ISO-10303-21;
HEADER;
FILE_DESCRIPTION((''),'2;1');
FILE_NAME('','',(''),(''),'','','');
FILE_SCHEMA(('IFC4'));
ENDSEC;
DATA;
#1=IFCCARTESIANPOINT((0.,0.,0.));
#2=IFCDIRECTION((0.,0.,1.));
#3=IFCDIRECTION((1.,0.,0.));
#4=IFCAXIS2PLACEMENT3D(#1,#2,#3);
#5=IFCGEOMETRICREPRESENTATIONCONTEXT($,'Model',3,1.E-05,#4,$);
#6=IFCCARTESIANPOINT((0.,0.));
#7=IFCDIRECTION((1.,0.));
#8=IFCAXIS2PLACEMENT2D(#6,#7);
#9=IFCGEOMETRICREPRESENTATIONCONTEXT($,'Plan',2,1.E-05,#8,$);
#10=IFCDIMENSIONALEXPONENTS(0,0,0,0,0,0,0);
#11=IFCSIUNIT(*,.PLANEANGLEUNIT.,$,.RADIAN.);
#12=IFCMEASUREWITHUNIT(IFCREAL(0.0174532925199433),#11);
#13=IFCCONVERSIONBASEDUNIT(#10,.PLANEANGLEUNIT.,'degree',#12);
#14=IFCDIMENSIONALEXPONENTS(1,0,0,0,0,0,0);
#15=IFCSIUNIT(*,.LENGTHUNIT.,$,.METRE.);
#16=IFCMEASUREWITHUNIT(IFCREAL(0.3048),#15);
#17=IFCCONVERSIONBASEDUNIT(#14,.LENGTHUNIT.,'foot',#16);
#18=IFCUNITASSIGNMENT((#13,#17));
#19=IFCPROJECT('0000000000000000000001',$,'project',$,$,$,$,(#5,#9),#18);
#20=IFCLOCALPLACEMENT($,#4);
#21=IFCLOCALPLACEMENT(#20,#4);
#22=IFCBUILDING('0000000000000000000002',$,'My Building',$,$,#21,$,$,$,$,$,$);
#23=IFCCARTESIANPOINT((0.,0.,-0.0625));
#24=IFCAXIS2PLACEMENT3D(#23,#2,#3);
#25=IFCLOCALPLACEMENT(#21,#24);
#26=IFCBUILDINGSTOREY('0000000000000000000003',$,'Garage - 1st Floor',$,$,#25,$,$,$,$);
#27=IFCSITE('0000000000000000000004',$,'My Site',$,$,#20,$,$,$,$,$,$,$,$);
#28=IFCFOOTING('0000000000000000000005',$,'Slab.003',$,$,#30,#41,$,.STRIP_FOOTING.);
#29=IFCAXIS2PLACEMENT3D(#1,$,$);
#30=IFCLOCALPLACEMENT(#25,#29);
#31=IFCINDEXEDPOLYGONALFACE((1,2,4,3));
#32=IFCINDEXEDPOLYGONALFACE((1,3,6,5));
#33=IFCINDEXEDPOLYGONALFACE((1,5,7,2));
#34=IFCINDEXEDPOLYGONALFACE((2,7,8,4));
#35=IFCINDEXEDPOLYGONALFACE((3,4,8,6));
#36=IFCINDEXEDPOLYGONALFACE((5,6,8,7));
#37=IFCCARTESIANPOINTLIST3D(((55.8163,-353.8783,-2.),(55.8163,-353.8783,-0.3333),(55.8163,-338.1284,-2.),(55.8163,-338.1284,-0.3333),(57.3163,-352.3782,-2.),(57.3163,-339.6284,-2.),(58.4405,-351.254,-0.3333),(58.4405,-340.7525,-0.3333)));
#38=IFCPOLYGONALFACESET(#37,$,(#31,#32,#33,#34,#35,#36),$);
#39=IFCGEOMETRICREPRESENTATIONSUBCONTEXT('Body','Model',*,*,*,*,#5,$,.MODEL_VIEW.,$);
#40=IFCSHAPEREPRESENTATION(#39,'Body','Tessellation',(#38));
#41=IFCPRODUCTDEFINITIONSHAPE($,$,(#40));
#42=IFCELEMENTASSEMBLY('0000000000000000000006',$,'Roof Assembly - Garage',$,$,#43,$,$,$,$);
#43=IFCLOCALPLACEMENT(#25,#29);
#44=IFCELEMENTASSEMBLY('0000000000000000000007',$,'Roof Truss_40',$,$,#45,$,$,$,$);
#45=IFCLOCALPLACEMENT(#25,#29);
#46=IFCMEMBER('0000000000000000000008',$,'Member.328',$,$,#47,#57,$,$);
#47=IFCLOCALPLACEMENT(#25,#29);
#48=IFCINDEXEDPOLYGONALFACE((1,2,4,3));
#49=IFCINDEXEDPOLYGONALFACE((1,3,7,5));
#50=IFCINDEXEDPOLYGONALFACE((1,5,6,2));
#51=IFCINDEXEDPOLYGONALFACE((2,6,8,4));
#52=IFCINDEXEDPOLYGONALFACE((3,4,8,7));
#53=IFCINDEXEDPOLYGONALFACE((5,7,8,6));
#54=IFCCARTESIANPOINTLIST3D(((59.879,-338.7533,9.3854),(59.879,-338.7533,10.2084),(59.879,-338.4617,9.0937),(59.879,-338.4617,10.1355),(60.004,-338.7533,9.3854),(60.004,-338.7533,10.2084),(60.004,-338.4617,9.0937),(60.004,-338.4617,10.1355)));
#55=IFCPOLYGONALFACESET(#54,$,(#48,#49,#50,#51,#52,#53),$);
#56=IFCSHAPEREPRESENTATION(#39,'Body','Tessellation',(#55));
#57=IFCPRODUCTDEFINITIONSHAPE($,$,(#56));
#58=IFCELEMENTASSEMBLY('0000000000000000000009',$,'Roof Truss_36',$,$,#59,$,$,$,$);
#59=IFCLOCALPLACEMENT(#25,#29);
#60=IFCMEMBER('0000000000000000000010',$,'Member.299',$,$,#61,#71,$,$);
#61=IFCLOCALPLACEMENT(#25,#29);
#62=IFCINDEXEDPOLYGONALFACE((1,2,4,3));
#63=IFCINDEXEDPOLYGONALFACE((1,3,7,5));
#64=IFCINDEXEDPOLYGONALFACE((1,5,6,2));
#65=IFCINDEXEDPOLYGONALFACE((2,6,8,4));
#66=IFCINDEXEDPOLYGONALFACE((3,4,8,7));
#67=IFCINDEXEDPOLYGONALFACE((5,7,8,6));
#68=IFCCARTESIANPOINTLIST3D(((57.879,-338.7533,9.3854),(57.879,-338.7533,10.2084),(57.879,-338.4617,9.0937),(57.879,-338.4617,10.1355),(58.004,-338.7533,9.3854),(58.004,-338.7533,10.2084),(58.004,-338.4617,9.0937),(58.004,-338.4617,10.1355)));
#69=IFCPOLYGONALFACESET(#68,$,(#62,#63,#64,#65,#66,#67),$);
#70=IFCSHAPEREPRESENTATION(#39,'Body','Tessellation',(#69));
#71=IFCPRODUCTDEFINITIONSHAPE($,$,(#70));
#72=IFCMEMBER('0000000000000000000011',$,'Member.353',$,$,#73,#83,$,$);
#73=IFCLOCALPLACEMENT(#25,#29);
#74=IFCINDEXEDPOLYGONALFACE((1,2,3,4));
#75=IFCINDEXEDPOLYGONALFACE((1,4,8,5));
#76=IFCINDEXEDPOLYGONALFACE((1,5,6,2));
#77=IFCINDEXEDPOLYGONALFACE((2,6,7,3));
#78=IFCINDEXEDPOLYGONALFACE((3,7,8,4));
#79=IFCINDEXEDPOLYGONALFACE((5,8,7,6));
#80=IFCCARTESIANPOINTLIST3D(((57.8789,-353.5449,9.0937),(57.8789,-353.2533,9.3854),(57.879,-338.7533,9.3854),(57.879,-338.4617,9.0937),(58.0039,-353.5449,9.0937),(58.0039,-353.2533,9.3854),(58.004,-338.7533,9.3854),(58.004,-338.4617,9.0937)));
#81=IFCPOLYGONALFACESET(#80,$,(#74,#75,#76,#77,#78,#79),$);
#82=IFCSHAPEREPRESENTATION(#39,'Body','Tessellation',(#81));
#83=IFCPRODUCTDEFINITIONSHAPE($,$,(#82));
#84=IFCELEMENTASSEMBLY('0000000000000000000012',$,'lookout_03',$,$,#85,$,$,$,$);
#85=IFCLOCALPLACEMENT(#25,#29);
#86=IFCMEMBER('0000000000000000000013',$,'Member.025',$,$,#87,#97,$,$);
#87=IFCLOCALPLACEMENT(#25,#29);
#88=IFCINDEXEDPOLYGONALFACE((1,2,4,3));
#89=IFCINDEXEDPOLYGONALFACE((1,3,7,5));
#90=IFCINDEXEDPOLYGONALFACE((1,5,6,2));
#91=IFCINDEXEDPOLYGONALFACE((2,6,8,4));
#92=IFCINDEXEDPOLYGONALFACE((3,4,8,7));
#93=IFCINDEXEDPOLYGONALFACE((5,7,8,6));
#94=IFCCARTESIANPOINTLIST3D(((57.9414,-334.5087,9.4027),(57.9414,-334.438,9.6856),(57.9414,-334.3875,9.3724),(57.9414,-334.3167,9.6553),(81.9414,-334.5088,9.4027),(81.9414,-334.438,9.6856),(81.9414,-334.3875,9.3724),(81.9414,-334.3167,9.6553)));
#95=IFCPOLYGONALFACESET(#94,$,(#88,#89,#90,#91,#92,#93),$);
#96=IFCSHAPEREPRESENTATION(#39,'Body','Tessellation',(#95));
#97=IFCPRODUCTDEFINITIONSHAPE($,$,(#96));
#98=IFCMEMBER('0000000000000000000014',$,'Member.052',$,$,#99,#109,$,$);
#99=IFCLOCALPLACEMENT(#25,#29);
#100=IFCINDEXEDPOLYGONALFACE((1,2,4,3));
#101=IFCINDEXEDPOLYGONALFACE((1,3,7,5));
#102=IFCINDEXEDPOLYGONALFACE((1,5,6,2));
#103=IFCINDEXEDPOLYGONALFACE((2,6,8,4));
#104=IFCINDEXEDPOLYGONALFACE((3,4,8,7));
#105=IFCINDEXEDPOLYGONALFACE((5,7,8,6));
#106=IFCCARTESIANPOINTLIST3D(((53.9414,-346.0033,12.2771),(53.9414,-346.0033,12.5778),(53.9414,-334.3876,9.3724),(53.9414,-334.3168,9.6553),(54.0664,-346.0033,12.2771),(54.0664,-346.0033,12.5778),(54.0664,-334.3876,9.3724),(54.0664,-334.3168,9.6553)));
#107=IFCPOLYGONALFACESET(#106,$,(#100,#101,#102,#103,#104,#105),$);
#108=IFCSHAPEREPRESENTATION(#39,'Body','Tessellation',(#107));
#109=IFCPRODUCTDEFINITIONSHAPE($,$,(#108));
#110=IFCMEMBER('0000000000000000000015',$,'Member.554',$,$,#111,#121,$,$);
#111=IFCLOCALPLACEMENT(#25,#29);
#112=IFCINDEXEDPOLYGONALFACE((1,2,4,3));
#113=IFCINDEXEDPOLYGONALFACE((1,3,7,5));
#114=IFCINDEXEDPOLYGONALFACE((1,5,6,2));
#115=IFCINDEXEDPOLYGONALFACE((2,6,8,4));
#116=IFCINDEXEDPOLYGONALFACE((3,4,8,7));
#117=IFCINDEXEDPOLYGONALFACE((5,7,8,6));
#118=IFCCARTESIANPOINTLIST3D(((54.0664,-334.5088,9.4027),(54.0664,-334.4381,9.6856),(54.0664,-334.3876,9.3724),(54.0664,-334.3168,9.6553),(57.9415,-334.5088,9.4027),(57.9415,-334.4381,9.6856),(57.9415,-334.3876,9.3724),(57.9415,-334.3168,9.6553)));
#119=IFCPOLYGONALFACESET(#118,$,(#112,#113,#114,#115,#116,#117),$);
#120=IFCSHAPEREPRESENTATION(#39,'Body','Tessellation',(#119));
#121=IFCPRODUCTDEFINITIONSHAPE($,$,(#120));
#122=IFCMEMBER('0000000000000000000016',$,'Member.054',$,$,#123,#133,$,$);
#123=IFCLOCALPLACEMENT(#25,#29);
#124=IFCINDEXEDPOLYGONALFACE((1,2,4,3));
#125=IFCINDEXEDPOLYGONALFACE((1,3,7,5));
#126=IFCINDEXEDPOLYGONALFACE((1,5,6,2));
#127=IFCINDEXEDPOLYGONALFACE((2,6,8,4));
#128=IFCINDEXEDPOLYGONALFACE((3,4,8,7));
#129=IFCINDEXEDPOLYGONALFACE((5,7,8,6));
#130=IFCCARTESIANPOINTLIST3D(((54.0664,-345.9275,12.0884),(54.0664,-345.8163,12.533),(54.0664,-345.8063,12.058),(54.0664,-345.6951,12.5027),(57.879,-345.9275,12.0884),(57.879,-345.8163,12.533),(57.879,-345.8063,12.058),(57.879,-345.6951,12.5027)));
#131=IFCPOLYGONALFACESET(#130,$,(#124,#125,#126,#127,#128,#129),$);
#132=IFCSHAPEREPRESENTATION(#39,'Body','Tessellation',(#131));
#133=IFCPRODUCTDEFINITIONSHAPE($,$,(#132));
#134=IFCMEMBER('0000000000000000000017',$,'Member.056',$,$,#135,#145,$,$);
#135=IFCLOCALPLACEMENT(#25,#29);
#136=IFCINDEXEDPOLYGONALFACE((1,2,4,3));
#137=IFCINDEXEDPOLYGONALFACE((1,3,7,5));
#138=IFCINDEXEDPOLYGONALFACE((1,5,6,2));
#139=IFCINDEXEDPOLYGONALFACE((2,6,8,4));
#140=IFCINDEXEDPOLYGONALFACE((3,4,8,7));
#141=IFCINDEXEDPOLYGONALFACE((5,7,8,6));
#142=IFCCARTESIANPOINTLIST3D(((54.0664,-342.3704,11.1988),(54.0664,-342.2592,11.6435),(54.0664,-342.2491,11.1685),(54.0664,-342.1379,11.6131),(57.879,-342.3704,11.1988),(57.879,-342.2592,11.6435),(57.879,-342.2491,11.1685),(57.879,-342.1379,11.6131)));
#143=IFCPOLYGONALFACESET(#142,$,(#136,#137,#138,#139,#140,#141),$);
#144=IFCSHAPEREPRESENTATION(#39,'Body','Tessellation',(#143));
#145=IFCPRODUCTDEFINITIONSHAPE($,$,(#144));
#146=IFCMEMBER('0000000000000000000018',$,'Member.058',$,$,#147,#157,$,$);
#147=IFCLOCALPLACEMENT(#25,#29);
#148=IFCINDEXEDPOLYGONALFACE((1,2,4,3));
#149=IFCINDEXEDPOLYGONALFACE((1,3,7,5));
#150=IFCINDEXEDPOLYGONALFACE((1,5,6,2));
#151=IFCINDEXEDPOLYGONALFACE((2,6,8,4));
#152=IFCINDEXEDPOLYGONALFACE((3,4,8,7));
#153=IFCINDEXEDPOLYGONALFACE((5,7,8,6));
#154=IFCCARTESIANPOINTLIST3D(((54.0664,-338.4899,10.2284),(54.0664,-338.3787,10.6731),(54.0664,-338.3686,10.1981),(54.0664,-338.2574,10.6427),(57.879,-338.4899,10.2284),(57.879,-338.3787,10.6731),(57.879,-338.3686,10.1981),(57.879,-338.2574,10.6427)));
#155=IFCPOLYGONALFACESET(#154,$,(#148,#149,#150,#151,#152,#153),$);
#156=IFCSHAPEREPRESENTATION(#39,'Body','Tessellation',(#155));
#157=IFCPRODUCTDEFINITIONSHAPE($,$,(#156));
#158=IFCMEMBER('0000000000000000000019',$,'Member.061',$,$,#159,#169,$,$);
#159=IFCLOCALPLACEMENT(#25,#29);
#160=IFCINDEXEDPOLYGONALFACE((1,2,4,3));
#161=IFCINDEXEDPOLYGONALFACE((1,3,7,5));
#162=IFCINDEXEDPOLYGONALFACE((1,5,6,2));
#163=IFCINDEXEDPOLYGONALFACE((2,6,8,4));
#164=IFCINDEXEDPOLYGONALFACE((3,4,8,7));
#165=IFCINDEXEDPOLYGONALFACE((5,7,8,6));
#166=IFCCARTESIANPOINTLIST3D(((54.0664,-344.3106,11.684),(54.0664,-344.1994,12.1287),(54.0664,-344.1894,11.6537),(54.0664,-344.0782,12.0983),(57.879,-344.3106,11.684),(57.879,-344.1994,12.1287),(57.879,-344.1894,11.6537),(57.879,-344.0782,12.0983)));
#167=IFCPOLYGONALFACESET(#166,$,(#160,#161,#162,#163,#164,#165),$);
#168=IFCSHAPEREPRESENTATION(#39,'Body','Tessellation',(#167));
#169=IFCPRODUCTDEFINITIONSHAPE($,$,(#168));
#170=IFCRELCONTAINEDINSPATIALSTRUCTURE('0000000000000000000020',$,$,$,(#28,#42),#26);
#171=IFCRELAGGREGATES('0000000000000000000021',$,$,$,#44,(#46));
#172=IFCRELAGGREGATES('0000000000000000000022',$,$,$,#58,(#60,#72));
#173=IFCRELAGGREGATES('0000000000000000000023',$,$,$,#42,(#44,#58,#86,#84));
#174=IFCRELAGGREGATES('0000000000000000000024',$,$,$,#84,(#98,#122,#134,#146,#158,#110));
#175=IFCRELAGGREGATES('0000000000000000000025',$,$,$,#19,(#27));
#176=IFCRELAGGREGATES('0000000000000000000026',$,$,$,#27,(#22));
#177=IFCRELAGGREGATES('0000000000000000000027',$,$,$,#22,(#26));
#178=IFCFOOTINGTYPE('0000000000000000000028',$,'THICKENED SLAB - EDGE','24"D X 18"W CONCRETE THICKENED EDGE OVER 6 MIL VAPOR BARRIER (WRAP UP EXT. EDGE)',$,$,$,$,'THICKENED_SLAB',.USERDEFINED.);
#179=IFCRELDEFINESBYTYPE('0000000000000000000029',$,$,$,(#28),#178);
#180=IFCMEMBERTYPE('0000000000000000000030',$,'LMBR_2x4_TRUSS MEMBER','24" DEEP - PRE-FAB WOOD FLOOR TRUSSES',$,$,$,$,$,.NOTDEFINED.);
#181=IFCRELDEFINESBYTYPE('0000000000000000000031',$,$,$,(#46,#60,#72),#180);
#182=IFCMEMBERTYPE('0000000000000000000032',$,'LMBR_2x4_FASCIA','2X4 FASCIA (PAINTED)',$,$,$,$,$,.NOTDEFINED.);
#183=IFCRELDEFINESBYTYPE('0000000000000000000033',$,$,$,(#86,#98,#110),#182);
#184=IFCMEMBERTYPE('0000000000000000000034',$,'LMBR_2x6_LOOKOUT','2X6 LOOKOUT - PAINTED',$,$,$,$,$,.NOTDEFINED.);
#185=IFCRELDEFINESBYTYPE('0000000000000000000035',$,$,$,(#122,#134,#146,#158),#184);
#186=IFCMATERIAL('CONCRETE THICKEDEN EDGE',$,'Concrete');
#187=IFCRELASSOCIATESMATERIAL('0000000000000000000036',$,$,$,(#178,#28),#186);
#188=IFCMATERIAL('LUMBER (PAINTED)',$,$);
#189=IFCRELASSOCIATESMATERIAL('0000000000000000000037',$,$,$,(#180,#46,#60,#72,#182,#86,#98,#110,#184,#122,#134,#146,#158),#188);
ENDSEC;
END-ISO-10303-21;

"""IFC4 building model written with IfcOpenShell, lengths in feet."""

from ifc_helpers import new_model, entity, si_unit, converted_unit, frame, origin_with_axes, origin_2d_with_axis, place, context, subcontext, project, spatial, line, indexed_curve, outline, extrude, clip, halfspace, material, material_profile, profile_set, profile_usage, type_object, element, aggregate, save


model = new_model("IFC4")

# Units and contexts
model_context = context("Model", 3, precision=1e-05, world=origin_with_axes())
plan_context = context("Plan", 2, precision=1e-05, world=origin_2d_with_axis())
body_context = subcontext(model_context, "Body", "Model", "MODEL_VIEW")
ifc_project = project(units=[converted_unit("PLANEANGLEUNIT", "degree", entity("IfcReal", 0.0174532925199433), si_unit("PLANEANGLEUNIT", "RADIAN"), dimensions=[0, 0, 0, 0, 0, 0, 0]), converted_unit("LENGTHUNIT", "foot", entity("IfcReal", 0.3048), si_unit("LENGTHUNIT", "METRE"), dimensions=[1, 0, 0, 0, 0, 0, 0])], contexts=[model_context, plan_context])

# Site, building, storey
site_placement = place(None, origin_with_axes())
site = spatial("IfcSite", under=ifc_project, at=site_placement, Name="My Site")
building_placement = place(site_placement, origin_with_axes())
building = spatial("IfcBuilding", under=site, at=building_placement, Name="My Building")
storey_placement = place(building_placement, frame((0.0, 0.0, -0.0625), z_axis=(0.0, 0.0, 1.0), x_axis=(1.0, 0.0, 0.0)))
storey = spatial("IfcBuildingStorey", under=building, at=storey_placement, Name="Garage - 1st Floor")

# Footing
ifc_material_1 = material(Name="CONCRETE THICKEDEN EDGE", Category="Concrete")
ifc_material_profile_1 = material_profile(ifc_material_1, outline(indexed_curve([(0.0, 1.6667), (0.0, 0.0), (2.6242, 1.6667), (1.5, 0.0)], segments=[line(4, 2), line(2, 1), line(1, 3), line(3, 4)], self_intersect=False)))
ifc_profile_set_1 = profile_set([ifc_material_profile_1])
ifc_profile_usage_1 = profile_usage(ifc_profile_set_1, cardinal=5)
footing_type = type_object("IfcFootingType", Name="THICKENED SLAB - EDGE", Description="24\"D X 18\"W CONCRETE THICKENED EDGE OVER 6 MIL VAPOR BARRIER (WRAP UP EXT. EDGE)", ElementType="THICKENED_SLAB", PredefinedType="USERDEFINED", material=ifc_profile_set_1)
footing_placement = place(storey_placement, frame((55.8163, -338.1284, -2.0), z_axis=(0.000001, -1.0, 0.0), x_axis=(1.0, 0.000001, 0.0)))
element("IfcFooting", 1, at=footing_placement, inside=storey, type_object=footing_type, material=ifc_profile_usage_1, Name="Slab.003", PredefinedType="STRIP_FOOTING", context=body_context, shape_type="Clipping", body=[
    clip(clip(extrude(outline(indexed_curve([(0.0, 1.6667), (0.0, 0.0), (2.6242, 1.6667), (1.5, 0.0)], segments=[line(4, 2), line(2, 1), line(1, 3), line(3, 4)], self_intersect=False)), origin_with_axes(), (0.0, 0.0, 1.0), 15.7499), halfspace(frame((0.0, 2.0625, 15.7499), z_axis=(0.707107, 0.0, 0.707107), x_axis=(0.0, -1.0, 0.0)), False)), halfspace(frame((0.0, 2.0625, 0.0), z_axis=(0.707108, 0.0, -0.707106), x_axis=(0.0, -1.0, 0.0)), False)),
])

# Element assemblies, members
assembly_1_placement = place(storey_placement, frame((0.0, 0.0, 0.125), z_axis=(0.0, 0.0, 1.0), x_axis=(1.0, 0.0, 0.0)))
assembly_1 = element("IfcElementAssembly", 2, at=assembly_1_placement, inside=storey, Name="Roof Assembly - Garage")
assembly_2_placement = place(assembly_1_placement, frame((59.9415, -346.0033, 12.5192), z_axis=(0.0, 0.0, 1.0), x_axis=(0.0, 1.0, 0.0)))
assembly_2 = element("IfcElementAssembly", 3, at=assembly_2_placement, Name="Roof Truss_40")
ifc_material_2 = material(Name="LUMBER (PAINTED)")
ifc_material_profile_2 = material_profile(ifc_material_2, outline(indexed_curve([(-0.0625, -0.1458), (0.0625, -0.1458), (0.0625, 0.1458), (-0.0625, 0.1458), (-0.0625, -0.1458)])))
ifc_profile_set_2 = profile_set([ifc_material_profile_2])
member_type_1 = type_object("IfcMemberType", Name="LMBR_2x4_TRUSS MEMBER", Description="24\" DEEP - PRE-FAB WOOD FLOOR TRUSSES", PredefinedType="NOTDEFINED", material=ifc_profile_set_2)
ifc_profile_usage_2 = profile_usage(ifc_profile_set_2)
member_1_placement = place(assembly_2_placement, frame((7.3958, 0.0, -2.1806), z_axis=(0.0, 0.0, -1.0), x_axis=(0.0, -1.0, 0.0)))
member_1 = element("IfcMember", 4, at=member_1_placement, type_object=member_type_1, material=ifc_profile_usage_2, Name="Member.328", context=body_context, shape_type="Clipping", body=[
    clip(clip(extrude(outline(indexed_curve([(-0.0625, -0.1458), (0.0625, -0.1458), (0.0625, 0.1458), (-0.0625, 0.1458), (-0.0625, -0.1458)])), origin_with_axes(), (0.0, 0.0, 1.0), 1.3698), halfspace(frame((0.0, 7.5424, -1.5944), z_axis=(0.0, -0.242599, -0.970127), x_axis=(-1.0, 0.0, 0.0)), False)), halfspace(frame((-397.5032, -0.1458, 1.3698), z_axis=(0.0, 0.707099, 0.707114), x_axis=(1.0, 0.0, 0.0)), False)),
])
assembly_3_placement = place(assembly_1_placement, frame((57.9415, -346.0033, 12.5192), z_axis=(0.0, 0.0, 1.0), x_axis=(0.0, 1.0, 0.0)))
assembly_3 = element("IfcElementAssembly", 5, at=assembly_3_placement, Name="Roof Truss_36")
ifc_profile_usage_3 = profile_usage(ifc_profile_set_2)
member_2_placement = place(assembly_3_placement, frame((7.3958, 0.0, -2.1806), z_axis=(0.0, 0.0, -1.0), x_axis=(0.0, -1.0, 0.0)))
member_2 = element("IfcMember", 6, at=member_2_placement, type_object=member_type_1, material=ifc_profile_usage_3, Name="Member.299", context=body_context, shape_type="Clipping", body=[
    clip(clip(extrude(outline(indexed_curve([(-0.0625, -0.1458), (0.0625, -0.1458), (0.0625, 0.1458), (-0.0625, 0.1458), (-0.0625, -0.1458)])), origin_with_axes(), (0.0, 0.0, 1.0), 1.3698), halfspace(frame((0.0, 7.5424, -1.5944), z_axis=(0.0, -0.242599, -0.970127), x_axis=(-1.0, 0.0, 0.0)), False)), halfspace(frame((-397.5032, -0.1458, 1.3698), z_axis=(0.0, 0.707099, 0.707114), x_axis=(1.0, 0.0, 0.0)), False)),
])
ifc_profile_usage_4 = profile_usage(ifc_profile_set_2)
member_3_placement = place(assembly_3_placement, frame((7.5416, 0.0, -3.4046), z_axis=(-1.0, 0.0, 0.0), x_axis=(0.0, 1.0, 0.0)))
member_3 = element("IfcMember", 7, at=member_3_placement, type_object=member_type_1, material=ifc_profile_usage_4, Name="Member.353", context=body_context, shape_type="Clipping", body=[
    clip(clip(extrude(outline(indexed_curve([(-0.0625, -0.1458), (0.0625, -0.1458), (0.0625, 0.1458), (-0.0625, 0.1458), (-0.0625, -0.1458)])), origin_with_axes(), (0.0, 0.0, 1.0), 15.0833), halfspace(frame((397.5032, 0.1458, 0.0001), z_axis=(0.0, -0.707114, -0.707099), x_axis=(-1.0, 0.0, 0.0)), False)), halfspace(frame((397.5032, 0.1458, 15.0832), z_axis=(0.0, -0.707107, 0.707107), x_axis=(-1.0, 0.0, 0.0)), False)),
])
assembly_4_placement = place(assembly_1_placement, frame((57.9415, -346.0033, 12.5192), z_axis=(0.0, 0.0, 1.0), x_axis=(-0.000001, 1.0, 0.0)))
assembly_4 = element("IfcElementAssembly", 8, at=assembly_4_placement, Name="lookout_03")
aggregate(assembly_2, [member_1])
aggregate(assembly_3, [member_2, member_3])
ifc_material_profile_3 = material_profile(ifc_material_2, outline(indexed_curve([(-0.0625, -0.1458), (0.0625, -0.1458), (0.0625, 0.1458), (-0.0625, 0.1458), (-0.0625, -0.1458)])))
ifc_profile_set_3 = profile_set([ifc_material_profile_3])
ifc_profile_usage_5 = profile_usage(ifc_profile_set_3)
member_type_2 = type_object("IfcMemberType", Name="LMBR_2x4_FASCIA", Description="2X4 FASCIA (PAINTED)", PredefinedType="NOTDEFINED", material=ifc_profile_set_3)
member_4_placement = place(assembly_1_placement, frame((57.9414, -334.4127, 9.404), z_axis=(1.0, 0.0, 0.0), x_axis=(0.0, 0.970127, -0.242599)))
member_4 = element("IfcMember", 9, at=member_4_placement, type_object=member_type_2, material=ifc_profile_usage_5, Name="Member.025", context=body_context, shape_type="SweptSolid", body=[
    extrude(outline(indexed_curve([(-0.0625, -0.1458), (0.0625, -0.1458), (0.0625, 0.1458), (-0.0625, 0.1458), (-0.0625, -0.1458)])), origin_with_axes(), (0.0, 0.0, 1.0), 24.0),
])
aggregate(assembly_1, [assembly_2, assembly_3, member_4, assembly_4])
ifc_profile_usage_6 = profile_usage(ifc_profile_set_3)
member_5_placement = place(assembly_4_placement, frame((11.6511, 3.9375, -3.1303), z_axis=(-0.970127, 0.0, 0.242599), x_axis=(0.0, -1.0, 0.0)))
member_5 = element("IfcMember", 10, at=member_5_placement, type_object=member_type_2, material=ifc_profile_usage_6, Name="Member.052", context=body_context, shape_type="Clipping", body=[
    clip(extrude(outline(indexed_curve([(-0.0625, -0.1458), (0.0625, -0.1458), (0.0625, 0.1458), (-0.0625, 0.1458), (-0.0625, -0.1458)])), origin_with_axes(), (0.0, 0.0, 1.0), 12.6114), halfspace(frame((85.8788, 0.1458, 12.0464), z_axis=(0.0, -0.242599, 0.970127), x_axis=(-1.0, -0.000001, 0.0)), False)),
])
ifc_profile_usage_7 = profile_usage(ifc_profile_set_3)
member_6_placement = place(assembly_4_placement, frame((11.5905, 0.0, -3.1152), z_axis=(0.0, 1.0, 0.0), x_axis=(-0.970127, 0.0, 0.242599)))
member_6 = element("IfcMember", 11, at=member_6_placement, type_object=member_type_2, material=ifc_profile_usage_7, Name="Member.554", context=body_context, shape_type="SweptSolid", body=[
    extrude(outline(indexed_curve([(-0.0625, -0.1458), (0.0625, -0.1458), (0.0625, 0.1458), (-0.0625, 0.1458), (-0.0625, -0.1458)])), origin_with_axes(), (0.0, 0.0, 1.0), 3.875),
])
ifc_material_profile_4 = material_profile(ifc_material_2, outline(indexed_curve([(-0.0625, 0.2292), (0.0625, 0.2292), (0.0625, -0.2292), (-0.0625, -0.2292), (-0.0625, 0.2292)])))
ifc_profile_set_4 = profile_set([ifc_material_profile_4])
ifc_profile_usage_8 = profile_usage(ifc_profile_set_4)
member_type_3 = type_object("IfcMemberType", Name="LMBR_2x6_LOOKOUT", Description="2X6 LOOKOUT - PAINTED", PredefinedType="NOTDEFINED", material=ifc_profile_set_4)
member_7_placement = place(assembly_4_placement, frame((0.192, 0.0625, -0.3487), z_axis=(0.0, 1.0, 0.0), x_axis=(-0.970127, 0.0, 0.242599)))
member_7 = element("IfcMember", 12, at=member_7_placement, type_object=member_type_3, material=ifc_profile_usage_8, Name="Member.054", context=body_context, shape_type="SweptSolid", body=[
    extrude(outline(indexed_curve([(-0.0625, 0.2292), (0.0625, 0.2292), (0.0625, -0.2292), (-0.0625, -0.2292), (-0.0625, 0.2292)])), origin_with_axes(), (0.0, 0.0, 1.0), 3.8125),
])
ifc_profile_usage_9 = profile_usage(ifc_profile_set_4)
member_8_placement = place(assembly_4_placement, frame((3.7491, 0.0625, -1.2382), z_axis=(0.0, 1.0, 0.0), x_axis=(-0.970127, 0.0, 0.242599)))
member_8 = element("IfcMember", 13, at=member_8_placement, type_object=member_type_3, material=ifc_profile_usage_9, Name="Member.056", context=body_context, shape_type="SweptSolid", body=[
    extrude(outline(indexed_curve([(-0.0625, 0.2292), (0.0625, 0.2292), (0.0625, -0.2292), (-0.0625, -0.2292), (-0.0625, 0.2292)])), origin_with_axes(), (0.0, 0.0, 1.0), 3.8125),
])
ifc_profile_usage_10 = profile_usage(ifc_profile_set_4)
member_9_placement = place(assembly_4_placement, frame((7.6296, 0.0625, -2.2086), z_axis=(0.0, 1.0, 0.0), x_axis=(-0.970127, 0.0, 0.242599)))
member_9 = element("IfcMember", 14, at=member_9_placement, type_object=member_type_3, material=ifc_profile_usage_10, Name="Member.058", context=body_context, shape_type="SweptSolid", body=[
    extrude(outline(indexed_curve([(-0.0625, 0.2292), (0.0625, 0.2292), (0.0625, -0.2292), (-0.0625, -0.2292), (-0.0625, 0.2292)])), origin_with_axes(), (0.0, 0.0, 1.0), 3.8125),
])
ifc_profile_usage_11 = profile_usage(ifc_profile_set_4)
member_10_placement = place(assembly_4_placement, frame((1.8089, 0.0625, -0.753), z_axis=(0.0, 1.0, 0.0), x_axis=(-0.970127, 0.0, 0.242599)))
member_10 = element("IfcMember", 15, at=member_10_placement, type_object=member_type_3, material=ifc_profile_usage_11, Name="Member.061", context=body_context, shape_type="SweptSolid", body=[
    extrude(outline(indexed_curve([(-0.0625, 0.2292), (0.0625, 0.2292), (0.0625, -0.2292), (-0.0625, -0.2292), (-0.0625, 0.2292)])), origin_with_axes(), (0.0, 0.0, 1.0), 3.8125),
])
aggregate(assembly_4, [member_5, member_7, member_8, member_9, member_10, member_6])

save(model, "model.ifc")
